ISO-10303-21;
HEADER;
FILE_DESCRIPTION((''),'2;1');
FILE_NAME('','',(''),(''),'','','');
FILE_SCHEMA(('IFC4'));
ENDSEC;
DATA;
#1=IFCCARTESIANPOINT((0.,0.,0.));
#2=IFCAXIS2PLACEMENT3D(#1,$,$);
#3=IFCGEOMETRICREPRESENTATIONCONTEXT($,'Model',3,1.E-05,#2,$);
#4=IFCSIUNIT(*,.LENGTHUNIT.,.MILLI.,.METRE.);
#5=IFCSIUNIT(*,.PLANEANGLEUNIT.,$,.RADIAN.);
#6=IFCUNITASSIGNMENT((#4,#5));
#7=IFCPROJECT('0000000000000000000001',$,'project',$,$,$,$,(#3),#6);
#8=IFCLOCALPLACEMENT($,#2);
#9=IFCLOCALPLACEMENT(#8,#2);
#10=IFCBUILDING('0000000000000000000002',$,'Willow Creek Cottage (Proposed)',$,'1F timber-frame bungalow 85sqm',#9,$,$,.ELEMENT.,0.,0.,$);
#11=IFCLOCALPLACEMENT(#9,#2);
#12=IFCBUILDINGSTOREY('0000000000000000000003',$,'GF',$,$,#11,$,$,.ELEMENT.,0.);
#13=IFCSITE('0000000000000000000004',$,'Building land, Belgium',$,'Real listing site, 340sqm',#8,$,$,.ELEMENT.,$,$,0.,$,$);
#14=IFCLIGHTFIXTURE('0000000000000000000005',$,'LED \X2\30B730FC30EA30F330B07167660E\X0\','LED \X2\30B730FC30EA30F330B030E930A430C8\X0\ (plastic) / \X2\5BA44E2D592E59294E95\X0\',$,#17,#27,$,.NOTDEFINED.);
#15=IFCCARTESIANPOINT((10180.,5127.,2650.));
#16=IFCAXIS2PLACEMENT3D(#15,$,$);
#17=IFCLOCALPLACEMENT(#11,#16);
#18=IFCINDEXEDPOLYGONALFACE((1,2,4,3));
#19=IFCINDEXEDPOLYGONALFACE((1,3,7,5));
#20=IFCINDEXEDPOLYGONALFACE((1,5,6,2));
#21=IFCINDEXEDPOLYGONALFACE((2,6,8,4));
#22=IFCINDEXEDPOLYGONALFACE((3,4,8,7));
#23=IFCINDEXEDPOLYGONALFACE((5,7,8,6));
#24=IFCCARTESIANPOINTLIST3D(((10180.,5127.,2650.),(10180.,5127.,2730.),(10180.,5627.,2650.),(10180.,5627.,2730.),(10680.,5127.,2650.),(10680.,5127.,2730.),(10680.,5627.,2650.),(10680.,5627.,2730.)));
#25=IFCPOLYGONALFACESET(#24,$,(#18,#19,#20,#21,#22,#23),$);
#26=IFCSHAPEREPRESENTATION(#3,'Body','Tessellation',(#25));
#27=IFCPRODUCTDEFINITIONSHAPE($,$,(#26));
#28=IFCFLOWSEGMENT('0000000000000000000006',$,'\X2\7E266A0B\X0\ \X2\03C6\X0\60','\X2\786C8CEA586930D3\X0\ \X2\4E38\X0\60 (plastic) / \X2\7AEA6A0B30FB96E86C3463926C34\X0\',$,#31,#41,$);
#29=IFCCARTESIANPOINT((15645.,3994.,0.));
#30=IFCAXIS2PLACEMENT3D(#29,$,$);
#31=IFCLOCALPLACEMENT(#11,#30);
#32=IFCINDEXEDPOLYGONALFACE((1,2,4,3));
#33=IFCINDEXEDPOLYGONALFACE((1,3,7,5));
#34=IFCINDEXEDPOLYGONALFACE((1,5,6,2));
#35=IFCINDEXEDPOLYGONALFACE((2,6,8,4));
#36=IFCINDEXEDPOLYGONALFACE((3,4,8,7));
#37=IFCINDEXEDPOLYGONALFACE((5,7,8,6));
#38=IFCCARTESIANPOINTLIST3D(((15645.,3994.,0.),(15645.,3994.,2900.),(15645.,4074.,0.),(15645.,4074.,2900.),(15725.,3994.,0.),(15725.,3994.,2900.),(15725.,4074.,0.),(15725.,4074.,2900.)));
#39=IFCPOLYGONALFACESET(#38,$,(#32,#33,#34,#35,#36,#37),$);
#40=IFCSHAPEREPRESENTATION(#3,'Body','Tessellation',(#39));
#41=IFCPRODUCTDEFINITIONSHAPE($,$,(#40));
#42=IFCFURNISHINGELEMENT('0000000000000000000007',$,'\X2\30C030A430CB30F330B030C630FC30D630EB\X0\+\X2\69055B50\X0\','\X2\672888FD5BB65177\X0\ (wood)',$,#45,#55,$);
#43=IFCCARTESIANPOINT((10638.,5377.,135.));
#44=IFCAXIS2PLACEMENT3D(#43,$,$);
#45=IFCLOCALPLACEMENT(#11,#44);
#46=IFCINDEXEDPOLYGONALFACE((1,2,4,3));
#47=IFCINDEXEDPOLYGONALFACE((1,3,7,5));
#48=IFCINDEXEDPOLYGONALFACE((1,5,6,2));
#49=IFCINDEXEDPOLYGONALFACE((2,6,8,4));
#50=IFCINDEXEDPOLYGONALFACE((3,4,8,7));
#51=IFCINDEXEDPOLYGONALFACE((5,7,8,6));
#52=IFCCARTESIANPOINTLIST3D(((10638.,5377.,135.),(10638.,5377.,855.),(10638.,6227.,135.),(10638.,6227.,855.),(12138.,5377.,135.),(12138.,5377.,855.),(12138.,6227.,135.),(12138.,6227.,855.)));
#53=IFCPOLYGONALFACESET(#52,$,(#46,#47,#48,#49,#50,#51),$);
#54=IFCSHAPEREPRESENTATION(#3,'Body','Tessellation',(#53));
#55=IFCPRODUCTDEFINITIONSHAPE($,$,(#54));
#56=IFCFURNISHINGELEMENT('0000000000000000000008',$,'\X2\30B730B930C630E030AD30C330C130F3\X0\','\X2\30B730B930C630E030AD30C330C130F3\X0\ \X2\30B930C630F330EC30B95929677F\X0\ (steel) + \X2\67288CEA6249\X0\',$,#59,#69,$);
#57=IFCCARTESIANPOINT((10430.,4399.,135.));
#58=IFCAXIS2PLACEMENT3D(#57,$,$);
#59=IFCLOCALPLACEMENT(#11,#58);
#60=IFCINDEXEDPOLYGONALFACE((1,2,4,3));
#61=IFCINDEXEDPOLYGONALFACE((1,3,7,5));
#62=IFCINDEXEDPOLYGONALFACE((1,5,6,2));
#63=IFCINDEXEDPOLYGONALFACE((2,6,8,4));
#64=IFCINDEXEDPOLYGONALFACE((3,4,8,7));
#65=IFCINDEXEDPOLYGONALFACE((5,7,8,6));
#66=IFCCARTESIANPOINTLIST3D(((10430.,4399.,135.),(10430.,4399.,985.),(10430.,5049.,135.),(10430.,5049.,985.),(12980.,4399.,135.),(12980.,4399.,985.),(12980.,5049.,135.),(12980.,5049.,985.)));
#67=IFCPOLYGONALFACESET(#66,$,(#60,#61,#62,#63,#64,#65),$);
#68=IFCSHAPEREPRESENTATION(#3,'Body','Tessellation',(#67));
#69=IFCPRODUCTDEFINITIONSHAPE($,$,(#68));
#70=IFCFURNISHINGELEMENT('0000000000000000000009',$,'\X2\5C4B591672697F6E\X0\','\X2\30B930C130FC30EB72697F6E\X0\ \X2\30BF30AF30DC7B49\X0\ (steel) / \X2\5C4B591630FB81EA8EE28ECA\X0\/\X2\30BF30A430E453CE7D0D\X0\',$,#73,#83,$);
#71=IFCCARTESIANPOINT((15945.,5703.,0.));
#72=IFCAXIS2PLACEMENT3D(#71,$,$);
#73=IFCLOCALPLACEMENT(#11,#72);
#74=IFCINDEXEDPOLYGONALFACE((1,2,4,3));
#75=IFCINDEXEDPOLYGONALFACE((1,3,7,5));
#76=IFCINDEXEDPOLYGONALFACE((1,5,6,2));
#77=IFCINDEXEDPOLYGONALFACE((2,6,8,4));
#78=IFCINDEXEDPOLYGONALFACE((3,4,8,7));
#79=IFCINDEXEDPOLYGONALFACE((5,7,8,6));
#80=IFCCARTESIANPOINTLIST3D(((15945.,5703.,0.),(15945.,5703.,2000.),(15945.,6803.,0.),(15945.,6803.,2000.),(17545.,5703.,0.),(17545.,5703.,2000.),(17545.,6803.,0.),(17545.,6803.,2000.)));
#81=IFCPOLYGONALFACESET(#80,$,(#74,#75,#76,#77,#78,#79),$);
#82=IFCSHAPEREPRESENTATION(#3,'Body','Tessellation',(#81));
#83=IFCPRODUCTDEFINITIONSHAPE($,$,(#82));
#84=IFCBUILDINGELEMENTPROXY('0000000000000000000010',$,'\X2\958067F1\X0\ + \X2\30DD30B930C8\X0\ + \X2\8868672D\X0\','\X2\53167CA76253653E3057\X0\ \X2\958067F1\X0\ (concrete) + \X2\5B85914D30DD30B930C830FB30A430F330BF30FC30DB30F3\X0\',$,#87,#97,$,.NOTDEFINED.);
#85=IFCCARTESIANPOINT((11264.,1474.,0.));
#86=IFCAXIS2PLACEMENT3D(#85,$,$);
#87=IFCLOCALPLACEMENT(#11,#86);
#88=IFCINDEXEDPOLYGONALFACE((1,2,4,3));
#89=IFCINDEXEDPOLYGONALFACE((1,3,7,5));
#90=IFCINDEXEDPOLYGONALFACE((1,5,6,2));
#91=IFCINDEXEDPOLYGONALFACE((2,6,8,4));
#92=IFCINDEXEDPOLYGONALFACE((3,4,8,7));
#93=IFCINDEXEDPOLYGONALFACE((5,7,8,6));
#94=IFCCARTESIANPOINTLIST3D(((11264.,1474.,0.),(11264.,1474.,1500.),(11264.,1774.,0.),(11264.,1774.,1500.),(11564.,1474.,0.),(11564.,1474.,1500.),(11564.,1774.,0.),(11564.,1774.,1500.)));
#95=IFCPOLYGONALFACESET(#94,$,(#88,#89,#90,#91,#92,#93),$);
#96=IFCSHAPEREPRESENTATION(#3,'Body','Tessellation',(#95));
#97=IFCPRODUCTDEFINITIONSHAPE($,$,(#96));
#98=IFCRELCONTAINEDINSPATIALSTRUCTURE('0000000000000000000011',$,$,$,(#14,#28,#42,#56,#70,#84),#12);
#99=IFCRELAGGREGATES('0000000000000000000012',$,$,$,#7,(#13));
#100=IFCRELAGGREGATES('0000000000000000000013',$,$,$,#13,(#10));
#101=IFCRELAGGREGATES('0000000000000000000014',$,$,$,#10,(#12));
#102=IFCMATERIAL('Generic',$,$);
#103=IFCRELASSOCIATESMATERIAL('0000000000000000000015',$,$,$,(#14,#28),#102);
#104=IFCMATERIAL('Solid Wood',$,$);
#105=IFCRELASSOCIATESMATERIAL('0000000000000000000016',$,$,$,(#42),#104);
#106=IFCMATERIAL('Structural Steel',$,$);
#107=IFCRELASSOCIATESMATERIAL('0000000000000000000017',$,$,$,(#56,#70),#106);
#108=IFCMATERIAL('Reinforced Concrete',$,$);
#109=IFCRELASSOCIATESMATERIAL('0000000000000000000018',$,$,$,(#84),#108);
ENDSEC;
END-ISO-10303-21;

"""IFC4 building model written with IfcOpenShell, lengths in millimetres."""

from ifc_helpers import new_model, si_unit, frame, frame_2d, origin, place, context, project, spatial, rectangle, extrude, material, element, save


model = new_model("IFC4")

# Units and contexts
model_context = context("Model", 3, precision=1e-05, world=origin())
ifc_project = project(units=[si_unit("LENGTHUNIT", "METRE", prefix="MILLI"), si_unit("PLANEANGLEUNIT", "RADIAN")], contexts=[model_context])

# Site, building, storey
site_placement = place(None, origin())
site = spatial("IfcSite", under=ifc_project, at=site_placement, Name="Building land, Belgium", ObjectType="Real listing site, 340sqm", CompositionType="ELEMENT", RefElevation=0.0)
building_placement = place(site_placement, origin())
building = spatial("IfcBuilding", under=site, at=building_placement, Name="Willow Creek Cottage (Proposed)", ObjectType="1F timber-frame bungalow 85sqm", CompositionType="ELEMENT", ElevationOfRefHeight=0.0, ElevationOfTerrain=0.0)
storey_placement = place(building_placement, origin())
storey = spatial("IfcBuildingStorey", under=building, at=storey_placement, Name="GF", CompositionType="ELEMENT", Elevation=0.0)

# Shared definitions
ifc_material_1 = material(Name="Solid Wood")

# Shared definitions
ifc_material_2 = material(Name="Structural Steel")

# Shared definitions
ifc_material_3 = material(Name="Reinforced Concrete")

# Shared definitions
ifc_material_4 = material(Name="Generic")

# Light fixture
light_fixture_placement = place(storey_placement, frame((10180.0, 5127.0, 2650.0)))
element("IfcLightFixture", 1, at=light_fixture_placement, inside=storey, material=ifc_material_4, Name="LED シーリング照明", Description="LED シーリングライト (plastic) / 室中央天井", PredefinedType="NOTDEFINED", context=model_context, shape_type="SweptSolid", body=[
    extrude(rectangle(XDim=500.0, YDim=500.0, at=frame_2d((250.0, 250.0))), frame((10180.0, 5127.0, 2650.0)), (0.0, 0.0, 1.0), 80.0),
])

# Flow segment
flow_segment_placement = place(storey_placement, frame((15645.0, 3994.0, 0.0)))
element("IfcFlowSegment", 2, at=flow_segment_placement, inside=storey, material=ifc_material_4, Name="縦樋 φ60", Description="硬質塩ビ 丸60 (plastic) / 竪樋・雨水排水", context=model_context, shape_type="SweptSolid", body=[
    extrude(rectangle(XDim=80.0, YDim=80.0, at=frame_2d((40.0, 40.0))), frame((15645.0, 3994.0, 0.0)), (0.0, 0.0, 1.0), 2900.0),
])

# Furnishing elements
furnishing_1_placement = place(storey_placement, frame((10638.0, 5377.0, 135.0)))
element("IfcFurnishingElement", 3, at=furnishing_1_placement, inside=storey, material=ifc_material_1, Name="ダイニングテーブル+椅子", Description="木製家具 (wood)", context=model_context, shape_type="SweptSolid", body=[
    extrude(rectangle(XDim=1500.0, YDim=850.0, at=frame_2d((750.0, 425.0))), frame((10638.0, 5377.0, 135.0)), (0.0, 0.0, 1.0), 720.0),
])
furnishing_2_placement = place(storey_placement, frame((10430.0, 4399.0, 135.0)))
element("IfcFurnishingElement", 4, at=furnishing_2_placement, inside=storey, material=ifc_material_2, Name="システムキッチン", Description="システムキッチン ステンレス天板 (steel) + 木質扉", context=model_context, shape_type="SweptSolid", body=[
    extrude(rectangle(XDim=2550.0, YDim=650.0, at=frame_2d((1275.0, 325.0))), frame((10430.0, 4399.0, 135.0)), (0.0, 0.0, 1.0), 850.0),
])
furnishing_3_placement = place(storey_placement, frame((15945.0, 5703.0, 0.0)))
element("IfcFurnishingElement", 5, at=furnishing_3_placement, inside=storey, material=ifc_material_2, Name="屋外物置", Description="スチール物置 タクボ等 (steel) / 屋外・自転車/タイヤ収納", context=model_context, shape_type="SweptSolid", body=[
    extrude(rectangle(XDim=1600.0, YDim=1100.0, at=frame_2d((800.0, 550.0))), frame((15945.0, 5703.0, 0.0)), (0.0, 0.0, 1.0), 2000.0),
])

# Building element proxy
proxy_placement = place(storey_placement, frame((11264.0, 1474.0, 0.0)))
element("IfcBuildingElementProxy", 6, at=proxy_placement, inside=storey, material=ifc_material_3, Name="門柱 + ポスト + 表札", Description="化粧打放し 門柱 (concrete) + 宅配ポスト・インターホン", PredefinedType="NOTDEFINED", context=model_context, shape_type="SweptSolid", body=[
    extrude(rectangle(XDim=300.0, YDim=300.0, at=frame_2d((150.0, 150.0))), frame((11264.0, 1474.0, 0.0)), (0.0, 0.0, 1.0), 1500.0),
])

save(model, "model.ifc")
